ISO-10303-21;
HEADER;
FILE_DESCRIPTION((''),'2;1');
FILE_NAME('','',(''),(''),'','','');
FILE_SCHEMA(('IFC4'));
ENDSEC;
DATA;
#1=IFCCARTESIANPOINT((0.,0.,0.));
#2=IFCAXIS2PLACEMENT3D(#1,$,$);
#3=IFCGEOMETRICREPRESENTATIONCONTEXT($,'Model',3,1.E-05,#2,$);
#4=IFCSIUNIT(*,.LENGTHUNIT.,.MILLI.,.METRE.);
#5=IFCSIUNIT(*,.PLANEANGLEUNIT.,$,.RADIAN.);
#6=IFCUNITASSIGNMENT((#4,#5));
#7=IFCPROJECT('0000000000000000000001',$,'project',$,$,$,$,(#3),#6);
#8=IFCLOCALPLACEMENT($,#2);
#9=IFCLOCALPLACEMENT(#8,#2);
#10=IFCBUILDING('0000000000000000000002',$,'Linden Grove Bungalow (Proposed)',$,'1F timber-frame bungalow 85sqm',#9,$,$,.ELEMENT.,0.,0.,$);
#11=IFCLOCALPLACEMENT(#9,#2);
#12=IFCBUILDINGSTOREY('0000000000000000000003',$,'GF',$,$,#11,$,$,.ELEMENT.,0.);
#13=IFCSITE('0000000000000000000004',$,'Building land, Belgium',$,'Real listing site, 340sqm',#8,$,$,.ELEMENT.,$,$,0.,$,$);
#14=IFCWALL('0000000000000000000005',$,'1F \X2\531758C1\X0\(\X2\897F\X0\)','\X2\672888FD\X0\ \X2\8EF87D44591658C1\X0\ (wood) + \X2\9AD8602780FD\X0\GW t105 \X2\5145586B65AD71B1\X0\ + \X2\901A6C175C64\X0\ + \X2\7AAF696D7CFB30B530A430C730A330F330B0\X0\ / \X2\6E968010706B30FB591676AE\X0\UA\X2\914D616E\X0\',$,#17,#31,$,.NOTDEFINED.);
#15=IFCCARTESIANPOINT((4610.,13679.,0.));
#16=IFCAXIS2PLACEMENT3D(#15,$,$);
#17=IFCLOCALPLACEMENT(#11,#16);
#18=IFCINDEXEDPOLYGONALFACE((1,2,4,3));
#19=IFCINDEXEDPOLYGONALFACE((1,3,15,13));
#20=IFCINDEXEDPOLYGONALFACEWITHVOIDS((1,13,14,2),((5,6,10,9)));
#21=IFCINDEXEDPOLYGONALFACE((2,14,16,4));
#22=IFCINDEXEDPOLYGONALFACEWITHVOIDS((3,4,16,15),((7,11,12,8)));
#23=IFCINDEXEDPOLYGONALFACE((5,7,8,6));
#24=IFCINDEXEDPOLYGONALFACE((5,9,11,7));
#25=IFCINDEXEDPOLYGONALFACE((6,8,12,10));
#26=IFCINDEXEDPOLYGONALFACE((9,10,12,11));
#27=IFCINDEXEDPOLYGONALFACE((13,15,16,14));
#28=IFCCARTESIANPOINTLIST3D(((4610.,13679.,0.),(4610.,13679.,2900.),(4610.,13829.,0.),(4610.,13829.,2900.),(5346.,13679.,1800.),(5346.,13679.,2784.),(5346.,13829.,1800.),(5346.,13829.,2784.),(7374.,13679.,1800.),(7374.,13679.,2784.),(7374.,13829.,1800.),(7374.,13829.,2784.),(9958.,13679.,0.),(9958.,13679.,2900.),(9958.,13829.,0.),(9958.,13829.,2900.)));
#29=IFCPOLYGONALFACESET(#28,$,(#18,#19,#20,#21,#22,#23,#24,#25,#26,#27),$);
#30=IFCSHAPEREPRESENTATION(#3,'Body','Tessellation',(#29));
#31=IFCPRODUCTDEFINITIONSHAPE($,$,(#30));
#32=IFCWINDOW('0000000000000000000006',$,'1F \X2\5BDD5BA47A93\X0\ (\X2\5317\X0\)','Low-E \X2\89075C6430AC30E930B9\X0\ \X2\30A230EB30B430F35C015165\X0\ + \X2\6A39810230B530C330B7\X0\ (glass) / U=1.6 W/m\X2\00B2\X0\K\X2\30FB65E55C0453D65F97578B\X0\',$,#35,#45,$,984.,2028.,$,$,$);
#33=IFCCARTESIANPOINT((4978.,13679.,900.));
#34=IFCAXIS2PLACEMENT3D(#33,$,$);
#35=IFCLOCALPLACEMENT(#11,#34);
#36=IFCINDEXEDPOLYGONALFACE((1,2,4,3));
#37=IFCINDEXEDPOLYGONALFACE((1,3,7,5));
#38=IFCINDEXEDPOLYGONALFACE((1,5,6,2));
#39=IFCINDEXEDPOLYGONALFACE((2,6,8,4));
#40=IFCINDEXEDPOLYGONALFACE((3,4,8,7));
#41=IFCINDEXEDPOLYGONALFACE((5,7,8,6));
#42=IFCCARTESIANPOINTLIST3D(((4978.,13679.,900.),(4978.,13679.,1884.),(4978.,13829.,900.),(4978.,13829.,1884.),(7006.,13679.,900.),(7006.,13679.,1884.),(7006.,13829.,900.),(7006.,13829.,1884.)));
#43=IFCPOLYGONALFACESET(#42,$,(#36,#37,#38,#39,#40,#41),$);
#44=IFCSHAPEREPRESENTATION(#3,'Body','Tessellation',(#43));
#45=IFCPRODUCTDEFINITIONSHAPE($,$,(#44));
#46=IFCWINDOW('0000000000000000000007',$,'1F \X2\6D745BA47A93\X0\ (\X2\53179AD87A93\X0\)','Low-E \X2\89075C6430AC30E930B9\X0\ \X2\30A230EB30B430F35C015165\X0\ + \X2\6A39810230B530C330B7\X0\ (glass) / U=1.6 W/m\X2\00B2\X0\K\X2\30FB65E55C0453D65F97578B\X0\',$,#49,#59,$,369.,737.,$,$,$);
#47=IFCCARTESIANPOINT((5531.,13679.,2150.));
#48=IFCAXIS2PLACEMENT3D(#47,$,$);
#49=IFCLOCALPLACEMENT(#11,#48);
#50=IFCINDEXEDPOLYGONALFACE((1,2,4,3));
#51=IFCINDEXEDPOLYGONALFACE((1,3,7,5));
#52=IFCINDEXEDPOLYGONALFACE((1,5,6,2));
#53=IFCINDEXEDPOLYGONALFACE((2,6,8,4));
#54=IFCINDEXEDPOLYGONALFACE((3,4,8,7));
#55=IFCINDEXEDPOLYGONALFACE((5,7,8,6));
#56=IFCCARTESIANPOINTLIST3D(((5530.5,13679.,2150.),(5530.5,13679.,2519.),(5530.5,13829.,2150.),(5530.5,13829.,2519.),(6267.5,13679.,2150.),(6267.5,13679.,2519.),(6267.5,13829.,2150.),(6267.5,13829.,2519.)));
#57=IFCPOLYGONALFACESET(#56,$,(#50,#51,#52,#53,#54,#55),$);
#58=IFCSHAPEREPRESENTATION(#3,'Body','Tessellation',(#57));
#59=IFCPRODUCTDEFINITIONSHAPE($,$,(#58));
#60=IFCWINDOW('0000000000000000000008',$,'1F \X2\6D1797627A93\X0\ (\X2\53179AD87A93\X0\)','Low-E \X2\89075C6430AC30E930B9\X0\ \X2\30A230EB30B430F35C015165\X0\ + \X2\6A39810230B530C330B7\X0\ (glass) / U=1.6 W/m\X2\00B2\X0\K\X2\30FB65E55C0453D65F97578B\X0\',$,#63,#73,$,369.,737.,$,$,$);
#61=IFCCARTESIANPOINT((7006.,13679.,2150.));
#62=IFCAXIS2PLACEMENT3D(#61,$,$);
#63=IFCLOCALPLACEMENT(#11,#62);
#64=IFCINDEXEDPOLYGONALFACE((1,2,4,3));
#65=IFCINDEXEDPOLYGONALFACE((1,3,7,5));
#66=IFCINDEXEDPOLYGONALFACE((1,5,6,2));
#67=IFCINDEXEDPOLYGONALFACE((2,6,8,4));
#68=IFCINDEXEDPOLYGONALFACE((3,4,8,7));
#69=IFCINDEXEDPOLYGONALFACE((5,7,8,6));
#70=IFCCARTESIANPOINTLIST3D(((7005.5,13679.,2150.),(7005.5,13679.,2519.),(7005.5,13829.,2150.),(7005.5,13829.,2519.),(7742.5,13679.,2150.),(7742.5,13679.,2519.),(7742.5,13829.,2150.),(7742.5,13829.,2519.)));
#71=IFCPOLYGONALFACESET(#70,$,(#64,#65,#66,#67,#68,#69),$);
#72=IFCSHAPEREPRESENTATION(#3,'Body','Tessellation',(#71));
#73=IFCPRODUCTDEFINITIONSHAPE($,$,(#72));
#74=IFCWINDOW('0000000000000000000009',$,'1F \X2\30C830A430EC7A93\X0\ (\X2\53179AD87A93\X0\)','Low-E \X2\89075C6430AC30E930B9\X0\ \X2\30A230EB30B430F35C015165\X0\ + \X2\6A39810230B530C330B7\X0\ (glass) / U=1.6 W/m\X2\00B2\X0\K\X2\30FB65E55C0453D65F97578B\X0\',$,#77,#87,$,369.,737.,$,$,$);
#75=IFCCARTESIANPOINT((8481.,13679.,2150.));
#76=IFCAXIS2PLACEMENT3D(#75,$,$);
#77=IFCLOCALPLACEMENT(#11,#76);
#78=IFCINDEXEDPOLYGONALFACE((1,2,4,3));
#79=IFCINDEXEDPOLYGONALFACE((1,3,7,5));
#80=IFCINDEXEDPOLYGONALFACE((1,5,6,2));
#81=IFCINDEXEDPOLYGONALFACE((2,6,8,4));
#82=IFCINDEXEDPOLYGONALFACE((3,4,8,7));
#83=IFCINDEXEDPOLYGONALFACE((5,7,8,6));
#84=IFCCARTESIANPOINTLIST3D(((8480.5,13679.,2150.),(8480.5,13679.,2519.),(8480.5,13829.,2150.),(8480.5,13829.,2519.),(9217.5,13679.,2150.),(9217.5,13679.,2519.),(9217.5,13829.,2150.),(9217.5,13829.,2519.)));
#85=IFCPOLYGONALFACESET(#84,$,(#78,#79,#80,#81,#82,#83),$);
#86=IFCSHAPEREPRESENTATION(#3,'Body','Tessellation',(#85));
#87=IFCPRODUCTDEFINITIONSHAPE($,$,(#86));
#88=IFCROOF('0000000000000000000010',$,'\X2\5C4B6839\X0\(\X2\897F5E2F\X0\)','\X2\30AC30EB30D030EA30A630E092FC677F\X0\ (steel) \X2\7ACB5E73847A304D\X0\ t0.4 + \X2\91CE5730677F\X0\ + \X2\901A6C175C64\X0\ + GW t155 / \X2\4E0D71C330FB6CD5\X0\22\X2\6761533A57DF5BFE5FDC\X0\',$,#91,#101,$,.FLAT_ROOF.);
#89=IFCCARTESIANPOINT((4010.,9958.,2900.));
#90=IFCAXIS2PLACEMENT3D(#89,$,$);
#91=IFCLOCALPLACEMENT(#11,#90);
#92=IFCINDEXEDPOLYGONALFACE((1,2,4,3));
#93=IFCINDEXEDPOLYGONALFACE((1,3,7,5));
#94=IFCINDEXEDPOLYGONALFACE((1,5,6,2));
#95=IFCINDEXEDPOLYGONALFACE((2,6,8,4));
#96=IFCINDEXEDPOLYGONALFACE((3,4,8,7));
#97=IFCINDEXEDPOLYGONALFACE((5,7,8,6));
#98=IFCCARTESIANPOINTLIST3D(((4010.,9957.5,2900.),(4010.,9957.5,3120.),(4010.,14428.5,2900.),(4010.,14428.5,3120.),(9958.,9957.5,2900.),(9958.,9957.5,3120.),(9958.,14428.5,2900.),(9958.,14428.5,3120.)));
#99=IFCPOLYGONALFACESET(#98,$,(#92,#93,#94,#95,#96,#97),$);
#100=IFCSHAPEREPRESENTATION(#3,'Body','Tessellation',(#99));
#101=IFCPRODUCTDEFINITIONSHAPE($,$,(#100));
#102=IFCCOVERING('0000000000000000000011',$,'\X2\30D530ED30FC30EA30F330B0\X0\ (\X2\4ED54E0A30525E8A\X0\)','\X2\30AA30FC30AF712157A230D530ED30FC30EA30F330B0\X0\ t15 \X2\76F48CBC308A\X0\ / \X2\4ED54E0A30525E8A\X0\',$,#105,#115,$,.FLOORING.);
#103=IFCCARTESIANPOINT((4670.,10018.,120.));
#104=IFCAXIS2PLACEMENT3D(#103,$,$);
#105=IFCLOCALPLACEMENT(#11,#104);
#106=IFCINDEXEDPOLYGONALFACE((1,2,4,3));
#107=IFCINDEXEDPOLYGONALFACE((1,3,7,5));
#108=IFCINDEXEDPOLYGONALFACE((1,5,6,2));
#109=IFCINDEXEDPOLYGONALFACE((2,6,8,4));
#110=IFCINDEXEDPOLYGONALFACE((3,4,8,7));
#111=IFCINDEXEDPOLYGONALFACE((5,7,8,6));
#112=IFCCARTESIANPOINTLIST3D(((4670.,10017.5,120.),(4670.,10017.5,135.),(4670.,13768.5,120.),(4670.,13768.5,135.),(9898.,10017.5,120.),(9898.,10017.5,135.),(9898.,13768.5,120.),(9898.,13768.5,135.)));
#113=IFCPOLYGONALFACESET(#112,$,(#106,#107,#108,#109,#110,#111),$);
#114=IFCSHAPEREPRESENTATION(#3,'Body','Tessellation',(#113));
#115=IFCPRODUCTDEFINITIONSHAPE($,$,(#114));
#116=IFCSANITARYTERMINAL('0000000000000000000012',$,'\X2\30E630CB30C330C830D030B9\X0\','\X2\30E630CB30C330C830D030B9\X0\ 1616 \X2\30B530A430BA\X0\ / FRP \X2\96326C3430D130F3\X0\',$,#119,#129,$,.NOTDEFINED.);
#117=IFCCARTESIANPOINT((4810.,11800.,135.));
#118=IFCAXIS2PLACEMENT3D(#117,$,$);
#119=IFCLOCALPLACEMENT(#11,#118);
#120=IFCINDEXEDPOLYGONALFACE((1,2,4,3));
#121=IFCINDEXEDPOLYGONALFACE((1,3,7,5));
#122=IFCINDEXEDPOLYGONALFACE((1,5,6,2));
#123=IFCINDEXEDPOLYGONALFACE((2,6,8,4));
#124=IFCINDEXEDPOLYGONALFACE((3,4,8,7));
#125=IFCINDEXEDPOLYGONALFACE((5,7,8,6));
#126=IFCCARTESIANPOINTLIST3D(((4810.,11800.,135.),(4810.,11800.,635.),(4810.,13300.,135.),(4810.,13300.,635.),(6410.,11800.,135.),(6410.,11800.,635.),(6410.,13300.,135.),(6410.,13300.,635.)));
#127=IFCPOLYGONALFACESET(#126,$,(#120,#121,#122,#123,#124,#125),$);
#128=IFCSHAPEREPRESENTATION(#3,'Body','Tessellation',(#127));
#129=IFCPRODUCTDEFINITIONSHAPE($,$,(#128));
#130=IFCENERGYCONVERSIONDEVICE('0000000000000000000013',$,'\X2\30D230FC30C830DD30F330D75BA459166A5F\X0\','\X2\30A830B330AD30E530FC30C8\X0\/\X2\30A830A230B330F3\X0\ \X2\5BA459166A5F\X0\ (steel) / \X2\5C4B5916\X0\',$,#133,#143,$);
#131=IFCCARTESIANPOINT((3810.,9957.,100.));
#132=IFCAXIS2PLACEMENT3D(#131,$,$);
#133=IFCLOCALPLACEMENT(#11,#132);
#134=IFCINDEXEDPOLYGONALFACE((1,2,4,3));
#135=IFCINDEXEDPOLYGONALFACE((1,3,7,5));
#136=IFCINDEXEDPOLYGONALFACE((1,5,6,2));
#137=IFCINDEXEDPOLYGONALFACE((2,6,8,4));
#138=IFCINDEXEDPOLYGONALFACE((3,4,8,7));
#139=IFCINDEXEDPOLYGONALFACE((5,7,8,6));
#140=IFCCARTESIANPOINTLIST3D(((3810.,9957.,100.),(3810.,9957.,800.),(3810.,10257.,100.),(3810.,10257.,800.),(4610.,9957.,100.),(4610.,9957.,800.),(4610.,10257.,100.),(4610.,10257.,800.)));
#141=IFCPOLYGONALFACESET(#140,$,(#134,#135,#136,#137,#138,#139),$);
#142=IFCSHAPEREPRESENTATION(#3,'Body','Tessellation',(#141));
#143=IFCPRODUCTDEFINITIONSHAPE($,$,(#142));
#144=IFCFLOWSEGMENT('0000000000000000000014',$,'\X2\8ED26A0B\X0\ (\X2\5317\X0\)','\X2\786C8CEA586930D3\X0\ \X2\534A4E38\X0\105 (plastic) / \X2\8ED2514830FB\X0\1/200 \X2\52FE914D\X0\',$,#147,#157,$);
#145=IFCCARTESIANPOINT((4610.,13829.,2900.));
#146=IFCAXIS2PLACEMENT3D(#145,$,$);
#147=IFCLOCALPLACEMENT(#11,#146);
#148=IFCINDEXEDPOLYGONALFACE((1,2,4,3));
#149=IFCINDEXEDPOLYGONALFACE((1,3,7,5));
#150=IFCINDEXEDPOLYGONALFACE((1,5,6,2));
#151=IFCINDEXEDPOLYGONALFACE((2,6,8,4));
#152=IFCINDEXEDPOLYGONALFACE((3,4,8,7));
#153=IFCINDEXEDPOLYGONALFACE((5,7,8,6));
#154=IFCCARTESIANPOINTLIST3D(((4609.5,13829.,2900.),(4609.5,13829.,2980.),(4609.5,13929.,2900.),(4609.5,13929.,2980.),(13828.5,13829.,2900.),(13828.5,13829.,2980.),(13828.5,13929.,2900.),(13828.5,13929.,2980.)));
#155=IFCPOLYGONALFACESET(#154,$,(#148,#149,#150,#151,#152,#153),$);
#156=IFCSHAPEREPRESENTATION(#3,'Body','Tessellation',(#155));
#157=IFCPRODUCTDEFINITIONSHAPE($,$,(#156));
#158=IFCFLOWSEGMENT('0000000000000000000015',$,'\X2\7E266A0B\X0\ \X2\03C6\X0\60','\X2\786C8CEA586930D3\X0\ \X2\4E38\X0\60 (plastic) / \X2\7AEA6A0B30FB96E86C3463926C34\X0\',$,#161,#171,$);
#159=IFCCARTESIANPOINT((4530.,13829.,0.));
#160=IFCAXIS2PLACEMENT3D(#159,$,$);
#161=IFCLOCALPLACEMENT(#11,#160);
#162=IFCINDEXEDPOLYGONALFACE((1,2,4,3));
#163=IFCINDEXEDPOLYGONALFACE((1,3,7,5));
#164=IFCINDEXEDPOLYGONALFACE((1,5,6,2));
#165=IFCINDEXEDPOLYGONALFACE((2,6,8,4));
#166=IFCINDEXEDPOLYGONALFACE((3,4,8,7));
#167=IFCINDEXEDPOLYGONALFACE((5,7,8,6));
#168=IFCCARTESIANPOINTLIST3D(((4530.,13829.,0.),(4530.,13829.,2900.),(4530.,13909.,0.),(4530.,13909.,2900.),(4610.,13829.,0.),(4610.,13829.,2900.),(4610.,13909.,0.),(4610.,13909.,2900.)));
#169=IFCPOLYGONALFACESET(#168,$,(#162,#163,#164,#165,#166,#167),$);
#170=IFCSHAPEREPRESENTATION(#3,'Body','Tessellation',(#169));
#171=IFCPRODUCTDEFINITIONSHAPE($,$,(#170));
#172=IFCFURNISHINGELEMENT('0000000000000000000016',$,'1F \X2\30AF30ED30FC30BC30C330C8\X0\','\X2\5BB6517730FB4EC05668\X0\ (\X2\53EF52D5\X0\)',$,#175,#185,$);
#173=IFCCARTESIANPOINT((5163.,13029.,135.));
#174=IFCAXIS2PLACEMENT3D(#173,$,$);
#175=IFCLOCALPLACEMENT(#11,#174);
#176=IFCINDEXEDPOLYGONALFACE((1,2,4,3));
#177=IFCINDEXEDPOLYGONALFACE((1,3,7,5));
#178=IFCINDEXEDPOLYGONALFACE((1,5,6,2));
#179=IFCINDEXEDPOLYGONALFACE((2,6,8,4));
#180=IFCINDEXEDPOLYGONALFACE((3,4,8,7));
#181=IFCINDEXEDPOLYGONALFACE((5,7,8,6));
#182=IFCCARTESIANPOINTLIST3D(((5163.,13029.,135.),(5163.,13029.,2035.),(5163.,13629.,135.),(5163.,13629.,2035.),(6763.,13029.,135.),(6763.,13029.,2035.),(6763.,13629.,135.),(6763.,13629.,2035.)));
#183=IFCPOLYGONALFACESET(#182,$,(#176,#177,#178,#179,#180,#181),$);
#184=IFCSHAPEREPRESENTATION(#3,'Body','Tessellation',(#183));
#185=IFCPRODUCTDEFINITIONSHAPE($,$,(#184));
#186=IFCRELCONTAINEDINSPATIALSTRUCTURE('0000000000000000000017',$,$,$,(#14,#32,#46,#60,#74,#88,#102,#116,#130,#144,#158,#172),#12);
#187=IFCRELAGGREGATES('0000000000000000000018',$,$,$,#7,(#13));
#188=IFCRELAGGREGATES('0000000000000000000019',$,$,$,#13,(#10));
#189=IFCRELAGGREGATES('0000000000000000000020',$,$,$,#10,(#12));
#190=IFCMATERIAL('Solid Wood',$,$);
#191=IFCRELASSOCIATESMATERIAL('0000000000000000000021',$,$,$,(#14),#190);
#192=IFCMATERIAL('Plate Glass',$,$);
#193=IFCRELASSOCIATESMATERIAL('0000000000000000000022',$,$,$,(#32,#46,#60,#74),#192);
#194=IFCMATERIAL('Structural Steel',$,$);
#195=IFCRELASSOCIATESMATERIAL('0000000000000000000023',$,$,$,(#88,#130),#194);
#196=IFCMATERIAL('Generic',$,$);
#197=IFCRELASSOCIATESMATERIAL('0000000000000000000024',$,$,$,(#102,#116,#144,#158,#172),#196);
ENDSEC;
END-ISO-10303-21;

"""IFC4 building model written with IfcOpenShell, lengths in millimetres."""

from ifc_helpers import new_model, si_unit, frame, frame_2d, origin, place, context, project, spatial, rectangle, extrude, material, element, fill, save


model = new_model("IFC4")

# Units and contexts
model_context = context("Model", 3, precision=1e-05, world=origin())
ifc_project = project(units=[si_unit("LENGTHUNIT", "METRE", prefix="MILLI"), si_unit("PLANEANGLEUNIT", "RADIAN")], contexts=[model_context])

# Site, building, storey
site_placement = place(None, origin())
site = spatial("IfcSite", under=ifc_project, at=site_placement, Name="Building land, Belgium", ObjectType="Real listing site, 340sqm", CompositionType="ELEMENT", RefElevation=0.0)
building_placement = place(site_placement, origin())
building = spatial("IfcBuilding", under=site, at=building_placement, Name="Linden Grove Bungalow (Proposed)", ObjectType="1F timber-frame bungalow 85sqm", CompositionType="ELEMENT", ElevationOfRefHeight=0.0, ElevationOfTerrain=0.0)
storey_placement = place(building_placement, origin())
storey = spatial("IfcBuildingStorey", under=building, at=storey_placement, Name="GF", CompositionType="ELEMENT", Elevation=0.0)

# Shared definitions
ifc_material_1 = material(Name="Solid Wood")

# Wall, openings, windows
wall_1_placement = place(storey_placement, frame((4610.0, 13679.0, 0.0)))
wall_1 = element("IfcWall", 1, at=wall_1_placement, inside=storey, material=ifc_material_1, Name="1F 北壁(西)", Description="木製 軸組外壁 (wood) + 高性能GW t105 充填断熱 + 通気層 + 窯業系サイディング / 準耐火・外皮UA配慮", PredefinedType="NOTDEFINED", context=model_context, shape_type="SweptSolid", body=[
    extrude(rectangle(XDim=5348.0, YDim=150.0, at=frame_2d((2674.0, 75.0))), frame((4610.0, 13679.0, 0.0)), (0.0, 0.0, 1.0), 2900.0),
])
opening_1_placement = place(storey_placement, frame((4978.0, 13679.0, 900.0)))
opening_1 = element("IfcOpeningElement", 2, at=opening_1_placement, cuts=wall_1, PredefinedType="NOTDEFINED", context=model_context, shape_type="SweptSolid", body=[
    extrude(rectangle(XDim=2028.0, YDim=150.0, at=frame_2d((1014.0, 75.0))), frame((4978.0, 13679.0, 900.0)), (0.0, 0.0, 1.0), 984.0),
])
opening_2_placement = place(storey_placement, frame((5531.0, 13679.0, 2150.0)))
opening_2 = element("IfcOpeningElement", 3, at=opening_2_placement, cuts=wall_1, PredefinedType="NOTDEFINED", context=model_context, shape_type="SweptSolid", body=[
    extrude(rectangle(XDim=737.0, YDim=150.0, at=frame_2d((368.0, 75.0))), frame((5531.0, 13679.0, 2150.0)), (0.0, 0.0, 1.0), 369.0),
])
opening_3_placement = place(storey_placement, frame((7006.0, 13679.0, 2150.0)))
opening_3 = element("IfcOpeningElement", 4, at=opening_3_placement, cuts=wall_1, PredefinedType="NOTDEFINED", context=model_context, shape_type="SweptSolid", body=[
    extrude(rectangle(XDim=737.0, YDim=150.0, at=frame_2d((368.0, 75.0))), frame((7006.0, 13679.0, 2150.0)), (0.0, 0.0, 1.0), 369.0),
])
opening_4_placement = place(storey_placement, frame((8481.0, 13679.0, 2150.0)))
opening_4 = element("IfcOpeningElement", 5, at=opening_4_placement, cuts=wall_1, PredefinedType="NOTDEFINED", context=model_context, shape_type="SweptSolid", body=[
    extrude(rectangle(XDim=737.0, YDim=150.0, at=frame_2d((368.0, 75.0))), frame((8481.0, 13679.0, 2150.0)), (0.0, 0.0, 1.0), 369.0),
])
ifc_material_2 = material(Name="Plate Glass")
window_1_placement = place(storey_placement, frame((4978.0, 13679.0, 900.0)))
window_1 = element("IfcWindow", 6, at=window_1_placement, inside=storey, material=ifc_material_2, Name="1F 寝室窓 (北)", Description="Low-E 複層ガラス アルゴン封入 + 樹脂サッシ (glass) / U=1.6 W/m²K・日射取得型", OverallHeight=984.0, OverallWidth=2028.0, context=model_context, shape_type="SweptSolid", body=[
    extrude(rectangle(XDim=2028.0, YDim=150.0, at=frame_2d((1014.0, 75.0))), frame((4978.0, 13679.0, 900.0)), (0.0, 0.0, 1.0), 984.0),
])
fill(opening_1, window_1)
window_2_placement = place(storey_placement, frame((5531.0, 13679.0, 2150.0)))
window_2 = element("IfcWindow", 7, at=window_2_placement, inside=storey, material=ifc_material_2, Name="1F 浴室窓 (北高窓)", Description="Low-E 複層ガラス アルゴン封入 + 樹脂サッシ (glass) / U=1.6 W/m²K・日射取得型", OverallHeight=369.0, OverallWidth=737.0, context=model_context, shape_type="SweptSolid", body=[
    extrude(rectangle(XDim=737.0, YDim=150.0, at=frame_2d((368.0, 75.0))), frame((5531.0, 13679.0, 2150.0)), (0.0, 0.0, 1.0), 369.0),
])
fill(opening_2, window_2)
window_3_placement = place(storey_placement, frame((7006.0, 13679.0, 2150.0)))
window_3 = element("IfcWindow", 8, at=window_3_placement, inside=storey, material=ifc_material_2, Name="1F 洗面窓 (北高窓)", Description="Low-E 複層ガラス アルゴン封入 + 樹脂サッシ (glass) / U=1.6 W/m²K・日射取得型", OverallHeight=369.0, OverallWidth=737.0, context=model_context, shape_type="SweptSolid", body=[
    extrude(rectangle(XDim=737.0, YDim=150.0, at=frame_2d((368.0, 75.0))), frame((7006.0, 13679.0, 2150.0)), (0.0, 0.0, 1.0), 369.0),
])
fill(opening_3, window_3)
window_4_placement = place(storey_placement, frame((8481.0, 13679.0, 2150.0)))
window_4 = element("IfcWindow", 9, at=window_4_placement, inside=storey, material=ifc_material_2, Name="1F トイレ窓 (北高窓)", Description="Low-E 複層ガラス アルゴン封入 + 樹脂サッシ (glass) / U=1.6 W/m²K・日射取得型", OverallHeight=369.0, OverallWidth=737.0, context=model_context, shape_type="SweptSolid", body=[
    extrude(rectangle(XDim=737.0, YDim=150.0, at=frame_2d((368.0, 75.0))), frame((8481.0, 13679.0, 2150.0)), (0.0, 0.0, 1.0), 369.0),
])
fill(opening_4, window_4)

# Roof
ifc_material_3 = material(Name="Structural Steel")
roof_placement = place(storey_placement, frame((4010.0, 9958.0, 2900.0)))
element("IfcRoof", 10, at=roof_placement, inside=storey, material=ifc_material_3, Name="屋根(西帯)", Description="ガルバリウム鋼板 (steel) 立平葺き t0.4 + 野地板 + 通気層 + GW t155 / 不燃・法22条区域対応", PredefinedType="FLAT_ROOF", context=model_context, shape_type="SweptSolid", body=[
    extrude(rectangle(XDim=5948.0, YDim=4471.0, at=frame_2d((2974.0, 2235.0))), frame((4010.0, 9958.0, 2900.0)), (0.0, 0.0, 1.0), 220.0),
])

# Covering
ifc_material_4 = material(Name="Generic")
covering_placement = place(storey_placement, frame((4670.0, 10018.0, 120.0)))
element("IfcCovering", 11, at=covering_placement, inside=storey, material=ifc_material_4, Name="フローリング (仕上げ床)", Description="オーク無垢フローリング t15 直貼り / 仕上げ床", PredefinedType="FLOORING", context=model_context, shape_type="SweptSolid", body=[
    extrude(rectangle(XDim=5228.0, YDim=3751.0, at=frame_2d((2614.0, 1875.0))), frame((4670.0, 10018.0, 120.0)), (0.0, 0.0, 1.0), 15.0),
])

# Sanitary terminal
sanitary_terminal_placement = place(storey_placement, frame((4810.0, 11800.0, 135.0)))
element("IfcSanitaryTerminal", 12, at=sanitary_terminal_placement, inside=storey, material=ifc_material_4, Name="ユニットバス", Description="ユニットバス 1616 サイズ / FRP 防水パン", PredefinedType="NOTDEFINED", context=model_context, shape_type="SweptSolid", body=[
    extrude(rectangle(XDim=1600.0, YDim=1500.0, at=frame_2d((800.0, 750.0))), frame((4810.0, 11800.0, 135.0)), (0.0, 0.0, 1.0), 500.0),
])

# Energy conversion device
energy_conversion_device_placement = place(storey_placement, frame((3810.0, 9957.0, 100.0)))
element("IfcEnergyConversionDevice", 13, at=energy_conversion_device_placement, inside=storey, material=ifc_material_3, Name="ヒートポンプ室外機", Description="エコキュート/エアコン 室外機 (steel) / 屋外", context=model_context, shape_type="SweptSolid", body=[
    extrude(rectangle(XDim=800.0, YDim=300.0, at=frame_2d((400.0, 150.0))), frame((3810.0, 9957.0, 100.0)), (0.0, 0.0, 1.0), 700.0),
])

# Flow segments
flow_segment_1_placement = place(storey_placement, frame((4610.0, 13829.0, 2900.0)))
element("IfcFlowSegment", 14, at=flow_segment_1_placement, inside=storey, material=ifc_material_4, Name="軒樋 (北)", Description="硬質塩ビ 半丸105 (plastic) / 軒先・1/200 勾配", context=model_context, shape_type="SweptSolid", body=[
    extrude(rectangle(XDim=9219.0, YDim=100.0, at=frame_2d((4609.0, 50.0))), frame((4610.0, 13829.0, 2900.0)), (0.0, 0.0, 1.0), 80.0),
])
flow_segment_2_placement = place(storey_placement, frame((4530.0, 13829.0, 0.0)))
element("IfcFlowSegment", 15, at=flow_segment_2_placement, inside=storey, material=ifc_material_4, Name="縦樋 φ60", Description="硬質塩ビ 丸60 (plastic) / 竪樋・雨水排水", context=model_context, shape_type="SweptSolid", body=[
    extrude(rectangle(XDim=80.0, YDim=80.0, at=frame_2d((40.0, 40.0))), frame((4530.0, 13829.0, 0.0)), (0.0, 0.0, 1.0), 2900.0),
])

# Furnishing element
furnishing_1_placement = place(storey_placement, frame((5163.0, 13029.0, 135.0)))
element("IfcFurnishingElement", 16, at=furnishing_1_placement, inside=storey, material=ifc_material_4, Name="1F クローゼット", Description="家具・什器 (可動)", context=model_context, shape_type="SweptSolid", body=[
    extrude(rectangle(XDim=1600.0, YDim=600.0, at=frame_2d((800.0, 300.0))), frame((5163.0, 13029.0, 135.0)), (0.0, 0.0, 1.0), 1900.0),
])

save(model, "model.ifc")
